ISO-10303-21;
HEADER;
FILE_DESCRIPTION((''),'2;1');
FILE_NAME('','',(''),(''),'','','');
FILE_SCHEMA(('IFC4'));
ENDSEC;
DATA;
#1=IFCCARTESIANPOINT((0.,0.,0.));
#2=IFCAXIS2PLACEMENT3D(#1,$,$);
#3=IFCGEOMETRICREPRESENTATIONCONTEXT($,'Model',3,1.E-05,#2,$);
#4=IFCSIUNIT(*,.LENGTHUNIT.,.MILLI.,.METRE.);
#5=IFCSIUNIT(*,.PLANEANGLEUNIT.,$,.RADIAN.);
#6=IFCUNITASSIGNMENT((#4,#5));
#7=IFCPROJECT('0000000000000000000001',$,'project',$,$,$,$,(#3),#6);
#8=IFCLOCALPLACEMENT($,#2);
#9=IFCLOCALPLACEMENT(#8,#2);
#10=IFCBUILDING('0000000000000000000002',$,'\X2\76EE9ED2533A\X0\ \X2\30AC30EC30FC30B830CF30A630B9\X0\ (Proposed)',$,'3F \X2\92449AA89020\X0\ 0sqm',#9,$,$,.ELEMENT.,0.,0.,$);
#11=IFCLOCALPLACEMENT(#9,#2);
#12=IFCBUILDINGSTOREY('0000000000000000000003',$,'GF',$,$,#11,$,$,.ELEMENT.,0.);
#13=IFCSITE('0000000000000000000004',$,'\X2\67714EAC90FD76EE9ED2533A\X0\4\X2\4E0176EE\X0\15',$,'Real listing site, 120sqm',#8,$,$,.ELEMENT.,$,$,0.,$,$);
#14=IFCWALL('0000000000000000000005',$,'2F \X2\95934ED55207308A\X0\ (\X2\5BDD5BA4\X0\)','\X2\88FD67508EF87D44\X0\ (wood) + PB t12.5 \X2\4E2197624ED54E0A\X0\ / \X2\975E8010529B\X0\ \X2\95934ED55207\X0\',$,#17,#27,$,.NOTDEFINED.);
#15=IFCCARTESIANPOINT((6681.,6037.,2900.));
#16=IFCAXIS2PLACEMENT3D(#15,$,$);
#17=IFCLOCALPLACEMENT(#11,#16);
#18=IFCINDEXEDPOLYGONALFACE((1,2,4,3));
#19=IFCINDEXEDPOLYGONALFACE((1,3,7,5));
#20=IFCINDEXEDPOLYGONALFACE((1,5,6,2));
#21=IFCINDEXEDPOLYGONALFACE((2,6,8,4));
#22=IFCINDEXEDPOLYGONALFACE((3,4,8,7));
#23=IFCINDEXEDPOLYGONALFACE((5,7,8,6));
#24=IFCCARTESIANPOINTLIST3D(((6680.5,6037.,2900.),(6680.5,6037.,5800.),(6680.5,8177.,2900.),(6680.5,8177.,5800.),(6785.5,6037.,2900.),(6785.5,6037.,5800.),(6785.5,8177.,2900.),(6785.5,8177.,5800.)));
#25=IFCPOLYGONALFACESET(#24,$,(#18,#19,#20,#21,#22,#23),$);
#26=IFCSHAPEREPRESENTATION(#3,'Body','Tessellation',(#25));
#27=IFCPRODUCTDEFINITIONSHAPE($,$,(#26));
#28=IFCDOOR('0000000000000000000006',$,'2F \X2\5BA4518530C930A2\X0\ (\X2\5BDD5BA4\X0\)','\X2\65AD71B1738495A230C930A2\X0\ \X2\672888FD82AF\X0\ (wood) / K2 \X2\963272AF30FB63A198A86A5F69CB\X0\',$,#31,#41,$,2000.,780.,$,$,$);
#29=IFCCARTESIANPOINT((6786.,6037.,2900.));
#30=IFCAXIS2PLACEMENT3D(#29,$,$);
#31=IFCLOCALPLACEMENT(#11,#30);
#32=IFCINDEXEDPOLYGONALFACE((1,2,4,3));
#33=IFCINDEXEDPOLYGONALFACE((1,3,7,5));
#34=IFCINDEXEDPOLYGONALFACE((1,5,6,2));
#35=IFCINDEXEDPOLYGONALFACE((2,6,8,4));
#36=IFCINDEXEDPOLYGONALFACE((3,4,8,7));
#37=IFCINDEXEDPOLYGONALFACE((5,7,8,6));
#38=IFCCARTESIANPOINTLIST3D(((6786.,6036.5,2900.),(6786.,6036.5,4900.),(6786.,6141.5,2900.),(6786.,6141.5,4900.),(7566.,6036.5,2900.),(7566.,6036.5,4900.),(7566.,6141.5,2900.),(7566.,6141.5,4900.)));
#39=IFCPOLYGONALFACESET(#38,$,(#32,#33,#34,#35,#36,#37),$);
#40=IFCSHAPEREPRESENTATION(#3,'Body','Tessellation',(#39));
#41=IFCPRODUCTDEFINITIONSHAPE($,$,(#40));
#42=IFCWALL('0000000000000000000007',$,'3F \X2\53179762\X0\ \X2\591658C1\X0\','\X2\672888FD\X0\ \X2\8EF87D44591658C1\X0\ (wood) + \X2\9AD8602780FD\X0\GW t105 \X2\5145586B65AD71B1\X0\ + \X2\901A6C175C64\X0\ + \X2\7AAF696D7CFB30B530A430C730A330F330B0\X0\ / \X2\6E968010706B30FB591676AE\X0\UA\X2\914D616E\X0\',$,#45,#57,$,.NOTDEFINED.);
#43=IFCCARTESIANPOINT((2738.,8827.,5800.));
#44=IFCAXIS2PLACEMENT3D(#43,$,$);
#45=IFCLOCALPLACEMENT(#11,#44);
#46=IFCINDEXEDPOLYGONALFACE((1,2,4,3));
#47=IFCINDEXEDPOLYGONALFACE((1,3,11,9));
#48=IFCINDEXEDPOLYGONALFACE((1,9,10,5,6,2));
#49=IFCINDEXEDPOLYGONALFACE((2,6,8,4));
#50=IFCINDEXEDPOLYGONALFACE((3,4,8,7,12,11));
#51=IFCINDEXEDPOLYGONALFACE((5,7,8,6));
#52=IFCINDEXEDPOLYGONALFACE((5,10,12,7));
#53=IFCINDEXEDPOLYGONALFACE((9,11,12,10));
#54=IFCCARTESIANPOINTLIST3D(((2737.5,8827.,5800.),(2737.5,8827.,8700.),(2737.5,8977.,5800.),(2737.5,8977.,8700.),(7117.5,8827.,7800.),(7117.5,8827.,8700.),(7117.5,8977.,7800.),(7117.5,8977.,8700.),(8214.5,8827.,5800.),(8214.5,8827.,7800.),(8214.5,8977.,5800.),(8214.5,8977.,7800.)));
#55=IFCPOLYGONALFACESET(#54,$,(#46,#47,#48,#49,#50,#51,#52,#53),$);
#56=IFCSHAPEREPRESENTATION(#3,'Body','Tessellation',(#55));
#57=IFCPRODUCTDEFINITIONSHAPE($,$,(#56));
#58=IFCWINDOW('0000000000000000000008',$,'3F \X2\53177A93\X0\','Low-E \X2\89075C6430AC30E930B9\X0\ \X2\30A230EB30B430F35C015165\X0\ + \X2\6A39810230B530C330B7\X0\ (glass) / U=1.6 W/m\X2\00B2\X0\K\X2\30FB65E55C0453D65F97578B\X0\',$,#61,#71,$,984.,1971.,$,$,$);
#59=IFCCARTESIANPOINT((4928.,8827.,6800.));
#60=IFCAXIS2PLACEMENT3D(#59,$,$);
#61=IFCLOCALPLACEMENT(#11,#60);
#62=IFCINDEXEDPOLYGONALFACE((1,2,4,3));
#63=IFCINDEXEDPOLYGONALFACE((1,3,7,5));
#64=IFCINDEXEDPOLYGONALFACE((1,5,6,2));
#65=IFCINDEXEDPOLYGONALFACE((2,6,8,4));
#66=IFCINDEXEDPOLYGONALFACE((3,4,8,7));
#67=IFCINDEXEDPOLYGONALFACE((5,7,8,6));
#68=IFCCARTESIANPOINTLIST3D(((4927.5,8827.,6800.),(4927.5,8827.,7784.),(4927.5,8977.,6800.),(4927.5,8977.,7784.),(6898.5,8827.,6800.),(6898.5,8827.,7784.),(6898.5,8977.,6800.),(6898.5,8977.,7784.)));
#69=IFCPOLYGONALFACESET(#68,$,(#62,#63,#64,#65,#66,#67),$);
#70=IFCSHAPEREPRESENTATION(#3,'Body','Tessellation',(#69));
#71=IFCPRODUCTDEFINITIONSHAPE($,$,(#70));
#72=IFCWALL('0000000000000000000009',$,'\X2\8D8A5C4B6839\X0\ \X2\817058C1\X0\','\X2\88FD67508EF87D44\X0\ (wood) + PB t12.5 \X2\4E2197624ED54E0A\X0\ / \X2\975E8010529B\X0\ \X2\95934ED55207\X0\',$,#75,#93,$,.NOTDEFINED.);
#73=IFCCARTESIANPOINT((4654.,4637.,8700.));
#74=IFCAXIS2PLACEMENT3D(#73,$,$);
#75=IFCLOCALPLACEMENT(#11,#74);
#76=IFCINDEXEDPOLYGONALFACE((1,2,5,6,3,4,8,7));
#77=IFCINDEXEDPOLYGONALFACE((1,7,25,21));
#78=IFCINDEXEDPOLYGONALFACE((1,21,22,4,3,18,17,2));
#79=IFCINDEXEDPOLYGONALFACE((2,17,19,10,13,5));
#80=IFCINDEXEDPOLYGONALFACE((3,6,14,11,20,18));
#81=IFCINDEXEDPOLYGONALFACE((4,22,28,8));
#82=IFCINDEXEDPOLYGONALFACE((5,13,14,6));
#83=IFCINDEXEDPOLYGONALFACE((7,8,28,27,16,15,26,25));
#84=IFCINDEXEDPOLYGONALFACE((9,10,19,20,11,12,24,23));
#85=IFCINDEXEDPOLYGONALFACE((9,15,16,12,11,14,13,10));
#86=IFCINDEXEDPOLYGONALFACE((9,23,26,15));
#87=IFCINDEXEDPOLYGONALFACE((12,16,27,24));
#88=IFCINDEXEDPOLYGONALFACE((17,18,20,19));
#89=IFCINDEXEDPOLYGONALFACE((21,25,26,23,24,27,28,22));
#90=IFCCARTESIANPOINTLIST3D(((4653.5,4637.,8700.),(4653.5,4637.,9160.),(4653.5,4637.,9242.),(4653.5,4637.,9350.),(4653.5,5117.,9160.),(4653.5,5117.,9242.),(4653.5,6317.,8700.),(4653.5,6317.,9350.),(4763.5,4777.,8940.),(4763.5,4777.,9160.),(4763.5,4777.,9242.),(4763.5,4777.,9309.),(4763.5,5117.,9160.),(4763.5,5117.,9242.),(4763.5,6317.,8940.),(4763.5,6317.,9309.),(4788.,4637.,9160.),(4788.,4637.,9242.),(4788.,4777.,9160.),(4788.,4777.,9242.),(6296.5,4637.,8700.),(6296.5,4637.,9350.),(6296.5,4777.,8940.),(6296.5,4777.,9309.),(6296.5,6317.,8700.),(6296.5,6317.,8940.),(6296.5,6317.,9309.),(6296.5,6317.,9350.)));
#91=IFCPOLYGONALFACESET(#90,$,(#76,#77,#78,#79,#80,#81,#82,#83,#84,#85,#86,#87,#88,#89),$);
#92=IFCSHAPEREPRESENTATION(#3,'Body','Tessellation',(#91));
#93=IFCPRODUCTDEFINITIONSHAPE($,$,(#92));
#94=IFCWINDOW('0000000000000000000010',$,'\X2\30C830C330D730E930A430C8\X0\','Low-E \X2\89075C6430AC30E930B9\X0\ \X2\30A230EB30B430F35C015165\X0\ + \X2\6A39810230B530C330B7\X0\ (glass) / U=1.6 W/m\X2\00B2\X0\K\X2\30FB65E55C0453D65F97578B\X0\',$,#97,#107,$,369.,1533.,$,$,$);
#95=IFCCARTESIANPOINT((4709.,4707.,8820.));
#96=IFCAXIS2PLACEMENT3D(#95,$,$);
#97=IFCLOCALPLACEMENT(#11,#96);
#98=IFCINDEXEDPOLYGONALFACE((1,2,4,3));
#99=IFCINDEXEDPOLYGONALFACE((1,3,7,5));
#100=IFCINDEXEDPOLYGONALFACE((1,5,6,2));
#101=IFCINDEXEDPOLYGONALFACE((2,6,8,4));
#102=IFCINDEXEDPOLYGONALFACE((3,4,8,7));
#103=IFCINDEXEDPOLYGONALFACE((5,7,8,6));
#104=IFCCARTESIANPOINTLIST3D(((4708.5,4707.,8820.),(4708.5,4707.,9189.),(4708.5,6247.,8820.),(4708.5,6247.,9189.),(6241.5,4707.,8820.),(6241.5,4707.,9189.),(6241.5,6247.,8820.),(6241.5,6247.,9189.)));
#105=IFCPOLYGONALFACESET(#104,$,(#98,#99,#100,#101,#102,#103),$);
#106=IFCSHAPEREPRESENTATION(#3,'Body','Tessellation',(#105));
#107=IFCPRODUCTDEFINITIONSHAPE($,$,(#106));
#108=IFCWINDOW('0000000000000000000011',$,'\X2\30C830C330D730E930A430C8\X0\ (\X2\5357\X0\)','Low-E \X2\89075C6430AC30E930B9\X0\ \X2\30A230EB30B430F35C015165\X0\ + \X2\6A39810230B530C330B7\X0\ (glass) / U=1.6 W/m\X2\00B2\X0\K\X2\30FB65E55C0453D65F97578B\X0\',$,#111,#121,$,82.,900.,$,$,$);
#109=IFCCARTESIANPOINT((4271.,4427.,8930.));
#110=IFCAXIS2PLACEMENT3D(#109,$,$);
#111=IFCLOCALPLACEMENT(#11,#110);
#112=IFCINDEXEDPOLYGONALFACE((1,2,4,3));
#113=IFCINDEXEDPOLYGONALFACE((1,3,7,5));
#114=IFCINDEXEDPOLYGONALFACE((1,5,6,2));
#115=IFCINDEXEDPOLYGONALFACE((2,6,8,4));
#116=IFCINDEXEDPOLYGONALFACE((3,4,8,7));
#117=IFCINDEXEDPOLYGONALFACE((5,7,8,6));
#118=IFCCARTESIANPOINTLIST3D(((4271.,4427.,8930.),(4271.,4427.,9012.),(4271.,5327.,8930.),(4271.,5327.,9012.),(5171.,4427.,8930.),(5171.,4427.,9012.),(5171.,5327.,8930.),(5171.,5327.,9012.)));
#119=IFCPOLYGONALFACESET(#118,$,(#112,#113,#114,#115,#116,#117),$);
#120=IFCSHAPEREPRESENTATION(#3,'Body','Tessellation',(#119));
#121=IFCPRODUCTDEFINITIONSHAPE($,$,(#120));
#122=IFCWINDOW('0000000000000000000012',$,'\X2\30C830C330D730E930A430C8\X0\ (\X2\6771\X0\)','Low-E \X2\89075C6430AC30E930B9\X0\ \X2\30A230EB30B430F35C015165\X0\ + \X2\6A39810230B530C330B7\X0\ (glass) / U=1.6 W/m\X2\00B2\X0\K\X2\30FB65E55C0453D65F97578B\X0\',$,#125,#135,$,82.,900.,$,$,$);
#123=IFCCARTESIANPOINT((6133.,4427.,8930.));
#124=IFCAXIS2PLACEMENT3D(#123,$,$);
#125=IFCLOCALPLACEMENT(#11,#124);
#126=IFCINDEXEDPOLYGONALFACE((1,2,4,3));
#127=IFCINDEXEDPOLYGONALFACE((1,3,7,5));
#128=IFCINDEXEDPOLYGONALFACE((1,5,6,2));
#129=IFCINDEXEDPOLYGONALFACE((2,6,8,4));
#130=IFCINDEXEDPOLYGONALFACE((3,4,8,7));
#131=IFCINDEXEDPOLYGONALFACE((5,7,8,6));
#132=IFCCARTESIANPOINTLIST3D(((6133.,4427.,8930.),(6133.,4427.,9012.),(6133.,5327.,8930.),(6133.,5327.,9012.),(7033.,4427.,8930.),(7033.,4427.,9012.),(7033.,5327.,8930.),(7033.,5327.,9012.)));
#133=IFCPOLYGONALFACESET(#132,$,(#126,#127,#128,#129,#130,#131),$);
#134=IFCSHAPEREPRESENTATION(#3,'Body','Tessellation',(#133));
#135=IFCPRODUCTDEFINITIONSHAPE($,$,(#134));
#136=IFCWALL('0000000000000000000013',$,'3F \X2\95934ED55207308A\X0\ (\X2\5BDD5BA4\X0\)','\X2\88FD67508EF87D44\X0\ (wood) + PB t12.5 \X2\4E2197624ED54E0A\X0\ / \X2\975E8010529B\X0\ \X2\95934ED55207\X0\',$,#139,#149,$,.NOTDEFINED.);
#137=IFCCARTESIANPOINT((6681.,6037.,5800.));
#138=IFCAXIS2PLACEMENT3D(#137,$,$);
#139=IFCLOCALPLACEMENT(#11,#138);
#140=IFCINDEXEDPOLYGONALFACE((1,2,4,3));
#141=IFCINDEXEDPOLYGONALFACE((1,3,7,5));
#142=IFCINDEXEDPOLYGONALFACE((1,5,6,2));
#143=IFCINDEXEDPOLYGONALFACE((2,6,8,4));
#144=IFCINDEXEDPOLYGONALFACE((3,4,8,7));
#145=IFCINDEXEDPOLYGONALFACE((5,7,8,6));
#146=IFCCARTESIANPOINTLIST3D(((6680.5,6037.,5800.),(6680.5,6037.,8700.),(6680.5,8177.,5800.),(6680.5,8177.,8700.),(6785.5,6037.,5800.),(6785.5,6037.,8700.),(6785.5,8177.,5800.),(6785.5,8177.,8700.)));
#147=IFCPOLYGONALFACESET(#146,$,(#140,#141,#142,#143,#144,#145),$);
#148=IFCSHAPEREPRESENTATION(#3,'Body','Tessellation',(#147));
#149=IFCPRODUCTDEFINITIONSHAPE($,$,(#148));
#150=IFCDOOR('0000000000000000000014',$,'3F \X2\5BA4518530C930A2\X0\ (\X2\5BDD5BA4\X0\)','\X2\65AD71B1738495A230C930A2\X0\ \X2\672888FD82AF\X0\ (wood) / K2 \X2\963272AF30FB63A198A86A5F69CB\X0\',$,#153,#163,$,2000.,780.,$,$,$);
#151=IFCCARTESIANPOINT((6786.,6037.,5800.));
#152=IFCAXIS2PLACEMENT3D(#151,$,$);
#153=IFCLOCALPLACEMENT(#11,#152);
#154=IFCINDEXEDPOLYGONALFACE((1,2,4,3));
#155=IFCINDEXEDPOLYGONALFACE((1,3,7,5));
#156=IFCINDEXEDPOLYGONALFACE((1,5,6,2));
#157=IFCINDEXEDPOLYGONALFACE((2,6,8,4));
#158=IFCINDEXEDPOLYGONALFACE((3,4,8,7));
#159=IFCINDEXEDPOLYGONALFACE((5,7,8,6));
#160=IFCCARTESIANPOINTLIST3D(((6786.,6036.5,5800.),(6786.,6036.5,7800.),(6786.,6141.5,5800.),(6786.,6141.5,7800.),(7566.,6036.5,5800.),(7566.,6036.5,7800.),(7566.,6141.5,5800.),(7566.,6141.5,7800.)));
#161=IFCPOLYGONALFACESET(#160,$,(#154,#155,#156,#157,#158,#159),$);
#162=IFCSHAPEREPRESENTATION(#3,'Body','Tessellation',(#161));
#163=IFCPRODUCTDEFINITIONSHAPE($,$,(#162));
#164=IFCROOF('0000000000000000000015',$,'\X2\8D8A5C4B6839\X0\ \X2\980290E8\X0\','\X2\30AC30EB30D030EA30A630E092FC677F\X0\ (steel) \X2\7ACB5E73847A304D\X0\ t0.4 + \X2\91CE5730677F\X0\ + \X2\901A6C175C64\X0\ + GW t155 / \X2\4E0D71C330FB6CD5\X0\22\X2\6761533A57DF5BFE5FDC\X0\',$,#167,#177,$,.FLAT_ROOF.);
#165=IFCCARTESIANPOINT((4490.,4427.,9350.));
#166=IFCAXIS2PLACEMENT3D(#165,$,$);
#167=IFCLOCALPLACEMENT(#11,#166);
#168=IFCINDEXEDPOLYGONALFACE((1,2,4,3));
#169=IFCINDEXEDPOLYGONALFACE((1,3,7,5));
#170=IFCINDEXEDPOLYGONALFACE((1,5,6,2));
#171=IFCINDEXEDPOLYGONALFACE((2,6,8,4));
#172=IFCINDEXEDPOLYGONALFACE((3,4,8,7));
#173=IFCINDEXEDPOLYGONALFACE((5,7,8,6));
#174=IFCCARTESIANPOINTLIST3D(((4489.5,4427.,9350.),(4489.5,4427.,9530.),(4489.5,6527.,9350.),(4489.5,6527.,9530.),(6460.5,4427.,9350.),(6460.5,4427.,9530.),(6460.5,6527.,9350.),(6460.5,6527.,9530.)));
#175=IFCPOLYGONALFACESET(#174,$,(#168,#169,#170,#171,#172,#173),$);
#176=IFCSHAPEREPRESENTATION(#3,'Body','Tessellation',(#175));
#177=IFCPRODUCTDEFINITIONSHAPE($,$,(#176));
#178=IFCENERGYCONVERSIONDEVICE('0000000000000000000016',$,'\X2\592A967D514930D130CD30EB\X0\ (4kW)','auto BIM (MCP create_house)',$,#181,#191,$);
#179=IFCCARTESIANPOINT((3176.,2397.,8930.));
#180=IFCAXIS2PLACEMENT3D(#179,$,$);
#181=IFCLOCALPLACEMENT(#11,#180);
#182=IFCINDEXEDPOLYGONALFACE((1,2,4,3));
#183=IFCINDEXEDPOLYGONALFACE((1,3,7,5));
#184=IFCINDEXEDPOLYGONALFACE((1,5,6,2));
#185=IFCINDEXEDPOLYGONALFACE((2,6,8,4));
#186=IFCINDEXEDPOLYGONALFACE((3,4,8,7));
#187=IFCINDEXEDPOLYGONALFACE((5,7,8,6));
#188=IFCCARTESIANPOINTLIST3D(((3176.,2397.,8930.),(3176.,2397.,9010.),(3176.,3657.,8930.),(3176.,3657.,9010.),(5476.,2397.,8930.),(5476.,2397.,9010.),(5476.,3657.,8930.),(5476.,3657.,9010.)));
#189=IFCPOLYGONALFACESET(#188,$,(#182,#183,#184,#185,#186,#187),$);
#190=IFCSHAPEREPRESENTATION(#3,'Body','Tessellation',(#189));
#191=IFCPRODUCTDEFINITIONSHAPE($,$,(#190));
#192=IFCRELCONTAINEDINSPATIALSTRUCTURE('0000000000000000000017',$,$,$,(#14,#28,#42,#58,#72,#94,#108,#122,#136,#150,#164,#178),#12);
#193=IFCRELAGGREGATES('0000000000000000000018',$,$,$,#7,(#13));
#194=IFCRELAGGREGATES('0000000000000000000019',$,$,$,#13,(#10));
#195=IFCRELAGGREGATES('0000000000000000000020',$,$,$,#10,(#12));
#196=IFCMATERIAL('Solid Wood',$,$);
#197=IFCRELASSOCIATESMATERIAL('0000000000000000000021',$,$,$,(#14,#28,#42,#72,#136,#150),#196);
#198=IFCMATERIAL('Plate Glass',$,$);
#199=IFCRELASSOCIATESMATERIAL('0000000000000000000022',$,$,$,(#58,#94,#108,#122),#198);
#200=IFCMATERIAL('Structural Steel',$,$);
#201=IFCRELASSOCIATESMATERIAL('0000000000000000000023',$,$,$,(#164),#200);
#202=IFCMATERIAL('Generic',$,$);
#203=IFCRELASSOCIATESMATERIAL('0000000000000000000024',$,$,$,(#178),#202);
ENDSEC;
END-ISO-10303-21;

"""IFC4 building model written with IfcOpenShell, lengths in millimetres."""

from ifc_helpers import new_model, si_unit, frame, frame_2d, origin, place, context, project, spatial, rectangle, extrude, material, element, fill, save


model = new_model("IFC4")

# Units and contexts
model_context = context("Model", 3, precision=1e-05, world=origin())
ifc_project = project(units=[si_unit("LENGTHUNIT", "METRE", prefix="MILLI"), si_unit("PLANEANGLEUNIT", "RADIAN")], contexts=[model_context])

# Site, building, storey
site_placement = place(None, origin())
site = spatial("IfcSite", under=ifc_project, at=site_placement, Name="東京都目黒区4丁目15", ObjectType="Real listing site, 120sqm", CompositionType="ELEMENT", RefElevation=0.0)
building_placement = place(site_placement, origin())
building = spatial("IfcBuilding", under=site, at=building_placement, Name="目黒区 ガレージハウス (Proposed)", ObjectType="3F 鉄骨造 0sqm", CompositionType="ELEMENT", ElevationOfRefHeight=0.0, ElevationOfTerrain=0.0)
storey_placement = place(building_placement, origin())
storey = spatial("IfcBuildingStorey", under=building, at=storey_placement, Name="GF", CompositionType="ELEMENT", Elevation=0.0)

# Wall
ifc_material_1 = material(Name="Solid Wood")
wall_1_placement = place(storey_placement, frame((6681.0, 6037.0, 2900.0)))
element("IfcWall", 1, at=wall_1_placement, inside=storey, material=ifc_material_1, Name="2F 間仕切り (寝室)", Description="製材軸組 (wood) + PB t12.5 両面仕上 / 非耐力 間仕切", PredefinedType="NOTDEFINED", context=model_context, shape_type="SweptSolid", body=[
    extrude(rectangle(XDim=105.0, YDim=2140.0, at=frame_2d((52.0, 1070.0))), frame((6681.0, 6037.0, 2900.0)), (0.0, 0.0, 1.0), 2900.0),
])

# Door
door_1_placement = place(storey_placement, frame((6786.0, 6037.0, 2900.0)))
element("IfcDoor", 2, at=door_1_placement, inside=storey, material=ifc_material_1, Name="2F 室内ドア (寝室)", Description="断熱玄関ドア 木製芯 (wood) / K2 防犯・採風機構", OverallHeight=2000.0, OverallWidth=780.0, context=model_context, shape_type="SweptSolid", body=[
    extrude(rectangle(XDim=780.0, YDim=105.0, at=frame_2d((390.0, 52.0))), frame((6786.0, 6037.0, 2900.0)), (0.0, 0.0, 1.0), 2000.0),
])

# Wall, opening, window
wall_2_placement = place(storey_placement, frame((2738.0, 8827.0, 5800.0)))
wall_2 = element("IfcWall", 3, at=wall_2_placement, inside=storey, material=ifc_material_1, Name="3F 北面 外壁", Description="木製 軸組外壁 (wood) + 高性能GW t105 充填断熱 + 通気層 + 窯業系サイディング / 準耐火・外皮UA配慮", PredefinedType="NOTDEFINED", context=model_context, shape_type="SweptSolid", body=[
    extrude(rectangle(XDim=5477.0, YDim=150.0, at=frame_2d((2738.0, 75.0))), frame((2738.0, 8827.0, 5800.0)), (0.0, 0.0, 1.0), 2900.0),
])
opening_1_placement = place(storey_placement, frame((4928.0, 8827.0, 6800.0)))
opening_1 = element("IfcOpeningElement", 4, at=opening_1_placement, cuts=wall_2, PredefinedType="NOTDEFINED", context=model_context, shape_type="SweptSolid", body=[
    extrude(rectangle(XDim=1971.0, YDim=150.0, at=frame_2d((985.0, 75.0))), frame((4928.0, 8827.0, 6800.0)), (0.0, 0.0, 1.0), 984.0),
])
ifc_material_2 = material(Name="Plate Glass")
window_1_placement = place(storey_placement, frame((4928.0, 8827.0, 6800.0)))
window_1 = element("IfcWindow", 5, at=window_1_placement, inside=storey, material=ifc_material_2, Name="3F 北窓", Description="Low-E 複層ガラス アルゴン封入 + 樹脂サッシ (glass) / U=1.6 W/m²K・日射取得型", OverallHeight=984.0, OverallWidth=1971.0, context=model_context, shape_type="SweptSolid", body=[
    extrude(rectangle(XDim=1971.0, YDim=150.0, at=frame_2d((985.0, 75.0))), frame((4928.0, 8827.0, 6800.0)), (0.0, 0.0, 1.0), 984.0),
])
fill(opening_1, window_1)

# Wall, openings, windows
wall_3_placement = place(storey_placement, frame((4654.0, 4637.0, 8700.0)))
wall_3 = element("IfcWall", 6, at=wall_3_placement, inside=storey, material=ifc_material_1, Name="越屋根 腰壁", Description="製材軸組 (wood) + PB t12.5 両面仕上 / 非耐力 間仕切", PredefinedType="NOTDEFINED", context=model_context, shape_type="SweptSolid", body=[
    extrude(rectangle(XDim=1643.0, YDim=1680.0, at=frame_2d((821.0, 840.0))), frame((4654.0, 4637.0, 8700.0)), (0.0, 0.0, 1.0), 650.0),
])
opening_2_placement = place(storey_placement, frame((4709.0, 4707.0, 8820.0)))
opening_2 = element("IfcOpeningElement", 7, at=opening_2_placement, cuts=wall_3, PredefinedType="NOTDEFINED", context=model_context, shape_type="SweptSolid", body=[
    extrude(rectangle(XDim=1533.0, YDim=1540.0, at=frame_2d((766.0, 770.0))), frame((4709.0, 4707.0, 8820.0)), (0.0, 0.0, 1.0), 369.0),
])
opening_3_placement = place(storey_placement, frame((4271.0, 4427.0, 8930.0)))
opening_3 = element("IfcOpeningElement", 8, at=opening_3_placement, cuts=wall_3, PredefinedType="NOTDEFINED", context=model_context, shape_type="SweptSolid", body=[
    extrude(rectangle(XDim=900.0, YDim=900.0, at=frame_2d((450.0, 450.0))), frame((4271.0, 4427.0, 8930.0)), (0.0, 0.0, 1.0), 82.0),
])
opening_4_placement = place(storey_placement, frame((6133.0, 4427.0, 8930.0)))
opening_4 = element("IfcOpeningElement", 9, at=opening_4_placement, cuts=wall_3, PredefinedType="NOTDEFINED", context=model_context, shape_type="SweptSolid", body=[
    extrude(rectangle(XDim=900.0, YDim=900.0, at=frame_2d((450.0, 450.0))), frame((6133.0, 4427.0, 8930.0)), (0.0, 0.0, 1.0), 82.0),
])
window_2_placement = place(storey_placement, frame((4709.0, 4707.0, 8820.0)))
window_2 = element("IfcWindow", 10, at=window_2_placement, inside=storey, material=ifc_material_2, Name="トップライト", Description="Low-E 複層ガラス アルゴン封入 + 樹脂サッシ (glass) / U=1.6 W/m²K・日射取得型", OverallHeight=369.0, OverallWidth=1533.0, context=model_context, shape_type="SweptSolid", body=[
    extrude(rectangle(XDim=1533.0, YDim=1540.0, at=frame_2d((766.0, 770.0))), frame((4709.0, 4707.0, 8820.0)), (0.0, 0.0, 1.0), 369.0),
])
fill(opening_2, window_2)
window_3_placement = place(storey_placement, frame((4271.0, 4427.0, 8930.0)))
window_3 = element("IfcWindow", 11, at=window_3_placement, inside=storey, material=ifc_material_2, Name="トップライト (南)", Description="Low-E 複層ガラス アルゴン封入 + 樹脂サッシ (glass) / U=1.6 W/m²K・日射取得型", OverallHeight=82.0, OverallWidth=900.0, context=model_context, shape_type="SweptSolid", body=[
    extrude(rectangle(XDim=900.0, YDim=900.0, at=frame_2d((450.0, 450.0))), frame((4271.0, 4427.0, 8930.0)), (0.0, 0.0, 1.0), 82.0),
])
fill(opening_3, window_3)
window_4_placement = place(storey_placement, frame((6133.0, 4427.0, 8930.0)))
window_4 = element("IfcWindow", 12, at=window_4_placement, inside=storey, material=ifc_material_2, Name="トップライト (東)", Description="Low-E 複層ガラス アルゴン封入 + 樹脂サッシ (glass) / U=1.6 W/m²K・日射取得型", OverallHeight=82.0, OverallWidth=900.0, context=model_context, shape_type="SweptSolid", body=[
    extrude(rectangle(XDim=900.0, YDim=900.0, at=frame_2d((450.0, 450.0))), frame((6133.0, 4427.0, 8930.0)), (0.0, 0.0, 1.0), 82.0),
])
fill(opening_4, window_4)

# Wall
wall_4_placement = place(storey_placement, frame((6681.0, 6037.0, 5800.0)))
element("IfcWall", 13, at=wall_4_placement, inside=storey, material=ifc_material_1, Name="3F 間仕切り (寝室)", Description="製材軸組 (wood) + PB t12.5 両面仕上 / 非耐力 間仕切", PredefinedType="NOTDEFINED", context=model_context, shape_type="SweptSolid", body=[
    extrude(rectangle(XDim=105.0, YDim=2140.0, at=frame_2d((52.0, 1070.0))), frame((6681.0, 6037.0, 5800.0)), (0.0, 0.0, 1.0), 2900.0),
])

# Door
door_2_placement = place(storey_placement, frame((6786.0, 6037.0, 5800.0)))
element("IfcDoor", 14, at=door_2_placement, inside=storey, material=ifc_material_1, Name="3F 室内ドア (寝室)", Description="断熱玄関ドア 木製芯 (wood) / K2 防犯・採風機構", OverallHeight=2000.0, OverallWidth=780.0, context=model_context, shape_type="SweptSolid", body=[
    extrude(rectangle(XDim=780.0, YDim=105.0, at=frame_2d((390.0, 52.0))), frame((6786.0, 6037.0, 5800.0)), (0.0, 0.0, 1.0), 2000.0),
])

# Roof
ifc_material_3 = material(Name="Structural Steel")
roof_placement = place(storey_placement, frame((4490.0, 4427.0, 9350.0)))
element("IfcRoof", 15, at=roof_placement, inside=storey, material=ifc_material_3, Name="越屋根 頂部", Description="ガルバリウム鋼板 (steel) 立平葺き t0.4 + 野地板 + 通気層 + GW t155 / 不燃・法22条区域対応", PredefinedType="FLAT_ROOF", context=model_context, shape_type="SweptSolid", body=[
    extrude(rectangle(XDim=1971.0, YDim=2100.0, at=frame_2d((985.0, 1050.0))), frame((4490.0, 4427.0, 9350.0)), (0.0, 0.0, 1.0), 180.0),
])

# Energy conversion device
ifc_material_4 = material(Name="Generic")
energy_conversion_device_placement = place(storey_placement, frame((3176.0, 2397.0, 8930.0)))
element("IfcEnergyConversionDevice", 16, at=energy_conversion_device_placement, inside=storey, material=ifc_material_4, Name="太陽光パネル (4kW)", Description="auto BIM (MCP create_house)", context=model_context, shape_type="SweptSolid", body=[
    extrude(rectangle(XDim=2300.0, YDim=1260.0, at=frame_2d((1150.0, 630.0))), frame((3176.0, 2397.0, 8930.0)), (0.0, 0.0, 1.0), 80.0),
])

save(model, "model.ifc")
